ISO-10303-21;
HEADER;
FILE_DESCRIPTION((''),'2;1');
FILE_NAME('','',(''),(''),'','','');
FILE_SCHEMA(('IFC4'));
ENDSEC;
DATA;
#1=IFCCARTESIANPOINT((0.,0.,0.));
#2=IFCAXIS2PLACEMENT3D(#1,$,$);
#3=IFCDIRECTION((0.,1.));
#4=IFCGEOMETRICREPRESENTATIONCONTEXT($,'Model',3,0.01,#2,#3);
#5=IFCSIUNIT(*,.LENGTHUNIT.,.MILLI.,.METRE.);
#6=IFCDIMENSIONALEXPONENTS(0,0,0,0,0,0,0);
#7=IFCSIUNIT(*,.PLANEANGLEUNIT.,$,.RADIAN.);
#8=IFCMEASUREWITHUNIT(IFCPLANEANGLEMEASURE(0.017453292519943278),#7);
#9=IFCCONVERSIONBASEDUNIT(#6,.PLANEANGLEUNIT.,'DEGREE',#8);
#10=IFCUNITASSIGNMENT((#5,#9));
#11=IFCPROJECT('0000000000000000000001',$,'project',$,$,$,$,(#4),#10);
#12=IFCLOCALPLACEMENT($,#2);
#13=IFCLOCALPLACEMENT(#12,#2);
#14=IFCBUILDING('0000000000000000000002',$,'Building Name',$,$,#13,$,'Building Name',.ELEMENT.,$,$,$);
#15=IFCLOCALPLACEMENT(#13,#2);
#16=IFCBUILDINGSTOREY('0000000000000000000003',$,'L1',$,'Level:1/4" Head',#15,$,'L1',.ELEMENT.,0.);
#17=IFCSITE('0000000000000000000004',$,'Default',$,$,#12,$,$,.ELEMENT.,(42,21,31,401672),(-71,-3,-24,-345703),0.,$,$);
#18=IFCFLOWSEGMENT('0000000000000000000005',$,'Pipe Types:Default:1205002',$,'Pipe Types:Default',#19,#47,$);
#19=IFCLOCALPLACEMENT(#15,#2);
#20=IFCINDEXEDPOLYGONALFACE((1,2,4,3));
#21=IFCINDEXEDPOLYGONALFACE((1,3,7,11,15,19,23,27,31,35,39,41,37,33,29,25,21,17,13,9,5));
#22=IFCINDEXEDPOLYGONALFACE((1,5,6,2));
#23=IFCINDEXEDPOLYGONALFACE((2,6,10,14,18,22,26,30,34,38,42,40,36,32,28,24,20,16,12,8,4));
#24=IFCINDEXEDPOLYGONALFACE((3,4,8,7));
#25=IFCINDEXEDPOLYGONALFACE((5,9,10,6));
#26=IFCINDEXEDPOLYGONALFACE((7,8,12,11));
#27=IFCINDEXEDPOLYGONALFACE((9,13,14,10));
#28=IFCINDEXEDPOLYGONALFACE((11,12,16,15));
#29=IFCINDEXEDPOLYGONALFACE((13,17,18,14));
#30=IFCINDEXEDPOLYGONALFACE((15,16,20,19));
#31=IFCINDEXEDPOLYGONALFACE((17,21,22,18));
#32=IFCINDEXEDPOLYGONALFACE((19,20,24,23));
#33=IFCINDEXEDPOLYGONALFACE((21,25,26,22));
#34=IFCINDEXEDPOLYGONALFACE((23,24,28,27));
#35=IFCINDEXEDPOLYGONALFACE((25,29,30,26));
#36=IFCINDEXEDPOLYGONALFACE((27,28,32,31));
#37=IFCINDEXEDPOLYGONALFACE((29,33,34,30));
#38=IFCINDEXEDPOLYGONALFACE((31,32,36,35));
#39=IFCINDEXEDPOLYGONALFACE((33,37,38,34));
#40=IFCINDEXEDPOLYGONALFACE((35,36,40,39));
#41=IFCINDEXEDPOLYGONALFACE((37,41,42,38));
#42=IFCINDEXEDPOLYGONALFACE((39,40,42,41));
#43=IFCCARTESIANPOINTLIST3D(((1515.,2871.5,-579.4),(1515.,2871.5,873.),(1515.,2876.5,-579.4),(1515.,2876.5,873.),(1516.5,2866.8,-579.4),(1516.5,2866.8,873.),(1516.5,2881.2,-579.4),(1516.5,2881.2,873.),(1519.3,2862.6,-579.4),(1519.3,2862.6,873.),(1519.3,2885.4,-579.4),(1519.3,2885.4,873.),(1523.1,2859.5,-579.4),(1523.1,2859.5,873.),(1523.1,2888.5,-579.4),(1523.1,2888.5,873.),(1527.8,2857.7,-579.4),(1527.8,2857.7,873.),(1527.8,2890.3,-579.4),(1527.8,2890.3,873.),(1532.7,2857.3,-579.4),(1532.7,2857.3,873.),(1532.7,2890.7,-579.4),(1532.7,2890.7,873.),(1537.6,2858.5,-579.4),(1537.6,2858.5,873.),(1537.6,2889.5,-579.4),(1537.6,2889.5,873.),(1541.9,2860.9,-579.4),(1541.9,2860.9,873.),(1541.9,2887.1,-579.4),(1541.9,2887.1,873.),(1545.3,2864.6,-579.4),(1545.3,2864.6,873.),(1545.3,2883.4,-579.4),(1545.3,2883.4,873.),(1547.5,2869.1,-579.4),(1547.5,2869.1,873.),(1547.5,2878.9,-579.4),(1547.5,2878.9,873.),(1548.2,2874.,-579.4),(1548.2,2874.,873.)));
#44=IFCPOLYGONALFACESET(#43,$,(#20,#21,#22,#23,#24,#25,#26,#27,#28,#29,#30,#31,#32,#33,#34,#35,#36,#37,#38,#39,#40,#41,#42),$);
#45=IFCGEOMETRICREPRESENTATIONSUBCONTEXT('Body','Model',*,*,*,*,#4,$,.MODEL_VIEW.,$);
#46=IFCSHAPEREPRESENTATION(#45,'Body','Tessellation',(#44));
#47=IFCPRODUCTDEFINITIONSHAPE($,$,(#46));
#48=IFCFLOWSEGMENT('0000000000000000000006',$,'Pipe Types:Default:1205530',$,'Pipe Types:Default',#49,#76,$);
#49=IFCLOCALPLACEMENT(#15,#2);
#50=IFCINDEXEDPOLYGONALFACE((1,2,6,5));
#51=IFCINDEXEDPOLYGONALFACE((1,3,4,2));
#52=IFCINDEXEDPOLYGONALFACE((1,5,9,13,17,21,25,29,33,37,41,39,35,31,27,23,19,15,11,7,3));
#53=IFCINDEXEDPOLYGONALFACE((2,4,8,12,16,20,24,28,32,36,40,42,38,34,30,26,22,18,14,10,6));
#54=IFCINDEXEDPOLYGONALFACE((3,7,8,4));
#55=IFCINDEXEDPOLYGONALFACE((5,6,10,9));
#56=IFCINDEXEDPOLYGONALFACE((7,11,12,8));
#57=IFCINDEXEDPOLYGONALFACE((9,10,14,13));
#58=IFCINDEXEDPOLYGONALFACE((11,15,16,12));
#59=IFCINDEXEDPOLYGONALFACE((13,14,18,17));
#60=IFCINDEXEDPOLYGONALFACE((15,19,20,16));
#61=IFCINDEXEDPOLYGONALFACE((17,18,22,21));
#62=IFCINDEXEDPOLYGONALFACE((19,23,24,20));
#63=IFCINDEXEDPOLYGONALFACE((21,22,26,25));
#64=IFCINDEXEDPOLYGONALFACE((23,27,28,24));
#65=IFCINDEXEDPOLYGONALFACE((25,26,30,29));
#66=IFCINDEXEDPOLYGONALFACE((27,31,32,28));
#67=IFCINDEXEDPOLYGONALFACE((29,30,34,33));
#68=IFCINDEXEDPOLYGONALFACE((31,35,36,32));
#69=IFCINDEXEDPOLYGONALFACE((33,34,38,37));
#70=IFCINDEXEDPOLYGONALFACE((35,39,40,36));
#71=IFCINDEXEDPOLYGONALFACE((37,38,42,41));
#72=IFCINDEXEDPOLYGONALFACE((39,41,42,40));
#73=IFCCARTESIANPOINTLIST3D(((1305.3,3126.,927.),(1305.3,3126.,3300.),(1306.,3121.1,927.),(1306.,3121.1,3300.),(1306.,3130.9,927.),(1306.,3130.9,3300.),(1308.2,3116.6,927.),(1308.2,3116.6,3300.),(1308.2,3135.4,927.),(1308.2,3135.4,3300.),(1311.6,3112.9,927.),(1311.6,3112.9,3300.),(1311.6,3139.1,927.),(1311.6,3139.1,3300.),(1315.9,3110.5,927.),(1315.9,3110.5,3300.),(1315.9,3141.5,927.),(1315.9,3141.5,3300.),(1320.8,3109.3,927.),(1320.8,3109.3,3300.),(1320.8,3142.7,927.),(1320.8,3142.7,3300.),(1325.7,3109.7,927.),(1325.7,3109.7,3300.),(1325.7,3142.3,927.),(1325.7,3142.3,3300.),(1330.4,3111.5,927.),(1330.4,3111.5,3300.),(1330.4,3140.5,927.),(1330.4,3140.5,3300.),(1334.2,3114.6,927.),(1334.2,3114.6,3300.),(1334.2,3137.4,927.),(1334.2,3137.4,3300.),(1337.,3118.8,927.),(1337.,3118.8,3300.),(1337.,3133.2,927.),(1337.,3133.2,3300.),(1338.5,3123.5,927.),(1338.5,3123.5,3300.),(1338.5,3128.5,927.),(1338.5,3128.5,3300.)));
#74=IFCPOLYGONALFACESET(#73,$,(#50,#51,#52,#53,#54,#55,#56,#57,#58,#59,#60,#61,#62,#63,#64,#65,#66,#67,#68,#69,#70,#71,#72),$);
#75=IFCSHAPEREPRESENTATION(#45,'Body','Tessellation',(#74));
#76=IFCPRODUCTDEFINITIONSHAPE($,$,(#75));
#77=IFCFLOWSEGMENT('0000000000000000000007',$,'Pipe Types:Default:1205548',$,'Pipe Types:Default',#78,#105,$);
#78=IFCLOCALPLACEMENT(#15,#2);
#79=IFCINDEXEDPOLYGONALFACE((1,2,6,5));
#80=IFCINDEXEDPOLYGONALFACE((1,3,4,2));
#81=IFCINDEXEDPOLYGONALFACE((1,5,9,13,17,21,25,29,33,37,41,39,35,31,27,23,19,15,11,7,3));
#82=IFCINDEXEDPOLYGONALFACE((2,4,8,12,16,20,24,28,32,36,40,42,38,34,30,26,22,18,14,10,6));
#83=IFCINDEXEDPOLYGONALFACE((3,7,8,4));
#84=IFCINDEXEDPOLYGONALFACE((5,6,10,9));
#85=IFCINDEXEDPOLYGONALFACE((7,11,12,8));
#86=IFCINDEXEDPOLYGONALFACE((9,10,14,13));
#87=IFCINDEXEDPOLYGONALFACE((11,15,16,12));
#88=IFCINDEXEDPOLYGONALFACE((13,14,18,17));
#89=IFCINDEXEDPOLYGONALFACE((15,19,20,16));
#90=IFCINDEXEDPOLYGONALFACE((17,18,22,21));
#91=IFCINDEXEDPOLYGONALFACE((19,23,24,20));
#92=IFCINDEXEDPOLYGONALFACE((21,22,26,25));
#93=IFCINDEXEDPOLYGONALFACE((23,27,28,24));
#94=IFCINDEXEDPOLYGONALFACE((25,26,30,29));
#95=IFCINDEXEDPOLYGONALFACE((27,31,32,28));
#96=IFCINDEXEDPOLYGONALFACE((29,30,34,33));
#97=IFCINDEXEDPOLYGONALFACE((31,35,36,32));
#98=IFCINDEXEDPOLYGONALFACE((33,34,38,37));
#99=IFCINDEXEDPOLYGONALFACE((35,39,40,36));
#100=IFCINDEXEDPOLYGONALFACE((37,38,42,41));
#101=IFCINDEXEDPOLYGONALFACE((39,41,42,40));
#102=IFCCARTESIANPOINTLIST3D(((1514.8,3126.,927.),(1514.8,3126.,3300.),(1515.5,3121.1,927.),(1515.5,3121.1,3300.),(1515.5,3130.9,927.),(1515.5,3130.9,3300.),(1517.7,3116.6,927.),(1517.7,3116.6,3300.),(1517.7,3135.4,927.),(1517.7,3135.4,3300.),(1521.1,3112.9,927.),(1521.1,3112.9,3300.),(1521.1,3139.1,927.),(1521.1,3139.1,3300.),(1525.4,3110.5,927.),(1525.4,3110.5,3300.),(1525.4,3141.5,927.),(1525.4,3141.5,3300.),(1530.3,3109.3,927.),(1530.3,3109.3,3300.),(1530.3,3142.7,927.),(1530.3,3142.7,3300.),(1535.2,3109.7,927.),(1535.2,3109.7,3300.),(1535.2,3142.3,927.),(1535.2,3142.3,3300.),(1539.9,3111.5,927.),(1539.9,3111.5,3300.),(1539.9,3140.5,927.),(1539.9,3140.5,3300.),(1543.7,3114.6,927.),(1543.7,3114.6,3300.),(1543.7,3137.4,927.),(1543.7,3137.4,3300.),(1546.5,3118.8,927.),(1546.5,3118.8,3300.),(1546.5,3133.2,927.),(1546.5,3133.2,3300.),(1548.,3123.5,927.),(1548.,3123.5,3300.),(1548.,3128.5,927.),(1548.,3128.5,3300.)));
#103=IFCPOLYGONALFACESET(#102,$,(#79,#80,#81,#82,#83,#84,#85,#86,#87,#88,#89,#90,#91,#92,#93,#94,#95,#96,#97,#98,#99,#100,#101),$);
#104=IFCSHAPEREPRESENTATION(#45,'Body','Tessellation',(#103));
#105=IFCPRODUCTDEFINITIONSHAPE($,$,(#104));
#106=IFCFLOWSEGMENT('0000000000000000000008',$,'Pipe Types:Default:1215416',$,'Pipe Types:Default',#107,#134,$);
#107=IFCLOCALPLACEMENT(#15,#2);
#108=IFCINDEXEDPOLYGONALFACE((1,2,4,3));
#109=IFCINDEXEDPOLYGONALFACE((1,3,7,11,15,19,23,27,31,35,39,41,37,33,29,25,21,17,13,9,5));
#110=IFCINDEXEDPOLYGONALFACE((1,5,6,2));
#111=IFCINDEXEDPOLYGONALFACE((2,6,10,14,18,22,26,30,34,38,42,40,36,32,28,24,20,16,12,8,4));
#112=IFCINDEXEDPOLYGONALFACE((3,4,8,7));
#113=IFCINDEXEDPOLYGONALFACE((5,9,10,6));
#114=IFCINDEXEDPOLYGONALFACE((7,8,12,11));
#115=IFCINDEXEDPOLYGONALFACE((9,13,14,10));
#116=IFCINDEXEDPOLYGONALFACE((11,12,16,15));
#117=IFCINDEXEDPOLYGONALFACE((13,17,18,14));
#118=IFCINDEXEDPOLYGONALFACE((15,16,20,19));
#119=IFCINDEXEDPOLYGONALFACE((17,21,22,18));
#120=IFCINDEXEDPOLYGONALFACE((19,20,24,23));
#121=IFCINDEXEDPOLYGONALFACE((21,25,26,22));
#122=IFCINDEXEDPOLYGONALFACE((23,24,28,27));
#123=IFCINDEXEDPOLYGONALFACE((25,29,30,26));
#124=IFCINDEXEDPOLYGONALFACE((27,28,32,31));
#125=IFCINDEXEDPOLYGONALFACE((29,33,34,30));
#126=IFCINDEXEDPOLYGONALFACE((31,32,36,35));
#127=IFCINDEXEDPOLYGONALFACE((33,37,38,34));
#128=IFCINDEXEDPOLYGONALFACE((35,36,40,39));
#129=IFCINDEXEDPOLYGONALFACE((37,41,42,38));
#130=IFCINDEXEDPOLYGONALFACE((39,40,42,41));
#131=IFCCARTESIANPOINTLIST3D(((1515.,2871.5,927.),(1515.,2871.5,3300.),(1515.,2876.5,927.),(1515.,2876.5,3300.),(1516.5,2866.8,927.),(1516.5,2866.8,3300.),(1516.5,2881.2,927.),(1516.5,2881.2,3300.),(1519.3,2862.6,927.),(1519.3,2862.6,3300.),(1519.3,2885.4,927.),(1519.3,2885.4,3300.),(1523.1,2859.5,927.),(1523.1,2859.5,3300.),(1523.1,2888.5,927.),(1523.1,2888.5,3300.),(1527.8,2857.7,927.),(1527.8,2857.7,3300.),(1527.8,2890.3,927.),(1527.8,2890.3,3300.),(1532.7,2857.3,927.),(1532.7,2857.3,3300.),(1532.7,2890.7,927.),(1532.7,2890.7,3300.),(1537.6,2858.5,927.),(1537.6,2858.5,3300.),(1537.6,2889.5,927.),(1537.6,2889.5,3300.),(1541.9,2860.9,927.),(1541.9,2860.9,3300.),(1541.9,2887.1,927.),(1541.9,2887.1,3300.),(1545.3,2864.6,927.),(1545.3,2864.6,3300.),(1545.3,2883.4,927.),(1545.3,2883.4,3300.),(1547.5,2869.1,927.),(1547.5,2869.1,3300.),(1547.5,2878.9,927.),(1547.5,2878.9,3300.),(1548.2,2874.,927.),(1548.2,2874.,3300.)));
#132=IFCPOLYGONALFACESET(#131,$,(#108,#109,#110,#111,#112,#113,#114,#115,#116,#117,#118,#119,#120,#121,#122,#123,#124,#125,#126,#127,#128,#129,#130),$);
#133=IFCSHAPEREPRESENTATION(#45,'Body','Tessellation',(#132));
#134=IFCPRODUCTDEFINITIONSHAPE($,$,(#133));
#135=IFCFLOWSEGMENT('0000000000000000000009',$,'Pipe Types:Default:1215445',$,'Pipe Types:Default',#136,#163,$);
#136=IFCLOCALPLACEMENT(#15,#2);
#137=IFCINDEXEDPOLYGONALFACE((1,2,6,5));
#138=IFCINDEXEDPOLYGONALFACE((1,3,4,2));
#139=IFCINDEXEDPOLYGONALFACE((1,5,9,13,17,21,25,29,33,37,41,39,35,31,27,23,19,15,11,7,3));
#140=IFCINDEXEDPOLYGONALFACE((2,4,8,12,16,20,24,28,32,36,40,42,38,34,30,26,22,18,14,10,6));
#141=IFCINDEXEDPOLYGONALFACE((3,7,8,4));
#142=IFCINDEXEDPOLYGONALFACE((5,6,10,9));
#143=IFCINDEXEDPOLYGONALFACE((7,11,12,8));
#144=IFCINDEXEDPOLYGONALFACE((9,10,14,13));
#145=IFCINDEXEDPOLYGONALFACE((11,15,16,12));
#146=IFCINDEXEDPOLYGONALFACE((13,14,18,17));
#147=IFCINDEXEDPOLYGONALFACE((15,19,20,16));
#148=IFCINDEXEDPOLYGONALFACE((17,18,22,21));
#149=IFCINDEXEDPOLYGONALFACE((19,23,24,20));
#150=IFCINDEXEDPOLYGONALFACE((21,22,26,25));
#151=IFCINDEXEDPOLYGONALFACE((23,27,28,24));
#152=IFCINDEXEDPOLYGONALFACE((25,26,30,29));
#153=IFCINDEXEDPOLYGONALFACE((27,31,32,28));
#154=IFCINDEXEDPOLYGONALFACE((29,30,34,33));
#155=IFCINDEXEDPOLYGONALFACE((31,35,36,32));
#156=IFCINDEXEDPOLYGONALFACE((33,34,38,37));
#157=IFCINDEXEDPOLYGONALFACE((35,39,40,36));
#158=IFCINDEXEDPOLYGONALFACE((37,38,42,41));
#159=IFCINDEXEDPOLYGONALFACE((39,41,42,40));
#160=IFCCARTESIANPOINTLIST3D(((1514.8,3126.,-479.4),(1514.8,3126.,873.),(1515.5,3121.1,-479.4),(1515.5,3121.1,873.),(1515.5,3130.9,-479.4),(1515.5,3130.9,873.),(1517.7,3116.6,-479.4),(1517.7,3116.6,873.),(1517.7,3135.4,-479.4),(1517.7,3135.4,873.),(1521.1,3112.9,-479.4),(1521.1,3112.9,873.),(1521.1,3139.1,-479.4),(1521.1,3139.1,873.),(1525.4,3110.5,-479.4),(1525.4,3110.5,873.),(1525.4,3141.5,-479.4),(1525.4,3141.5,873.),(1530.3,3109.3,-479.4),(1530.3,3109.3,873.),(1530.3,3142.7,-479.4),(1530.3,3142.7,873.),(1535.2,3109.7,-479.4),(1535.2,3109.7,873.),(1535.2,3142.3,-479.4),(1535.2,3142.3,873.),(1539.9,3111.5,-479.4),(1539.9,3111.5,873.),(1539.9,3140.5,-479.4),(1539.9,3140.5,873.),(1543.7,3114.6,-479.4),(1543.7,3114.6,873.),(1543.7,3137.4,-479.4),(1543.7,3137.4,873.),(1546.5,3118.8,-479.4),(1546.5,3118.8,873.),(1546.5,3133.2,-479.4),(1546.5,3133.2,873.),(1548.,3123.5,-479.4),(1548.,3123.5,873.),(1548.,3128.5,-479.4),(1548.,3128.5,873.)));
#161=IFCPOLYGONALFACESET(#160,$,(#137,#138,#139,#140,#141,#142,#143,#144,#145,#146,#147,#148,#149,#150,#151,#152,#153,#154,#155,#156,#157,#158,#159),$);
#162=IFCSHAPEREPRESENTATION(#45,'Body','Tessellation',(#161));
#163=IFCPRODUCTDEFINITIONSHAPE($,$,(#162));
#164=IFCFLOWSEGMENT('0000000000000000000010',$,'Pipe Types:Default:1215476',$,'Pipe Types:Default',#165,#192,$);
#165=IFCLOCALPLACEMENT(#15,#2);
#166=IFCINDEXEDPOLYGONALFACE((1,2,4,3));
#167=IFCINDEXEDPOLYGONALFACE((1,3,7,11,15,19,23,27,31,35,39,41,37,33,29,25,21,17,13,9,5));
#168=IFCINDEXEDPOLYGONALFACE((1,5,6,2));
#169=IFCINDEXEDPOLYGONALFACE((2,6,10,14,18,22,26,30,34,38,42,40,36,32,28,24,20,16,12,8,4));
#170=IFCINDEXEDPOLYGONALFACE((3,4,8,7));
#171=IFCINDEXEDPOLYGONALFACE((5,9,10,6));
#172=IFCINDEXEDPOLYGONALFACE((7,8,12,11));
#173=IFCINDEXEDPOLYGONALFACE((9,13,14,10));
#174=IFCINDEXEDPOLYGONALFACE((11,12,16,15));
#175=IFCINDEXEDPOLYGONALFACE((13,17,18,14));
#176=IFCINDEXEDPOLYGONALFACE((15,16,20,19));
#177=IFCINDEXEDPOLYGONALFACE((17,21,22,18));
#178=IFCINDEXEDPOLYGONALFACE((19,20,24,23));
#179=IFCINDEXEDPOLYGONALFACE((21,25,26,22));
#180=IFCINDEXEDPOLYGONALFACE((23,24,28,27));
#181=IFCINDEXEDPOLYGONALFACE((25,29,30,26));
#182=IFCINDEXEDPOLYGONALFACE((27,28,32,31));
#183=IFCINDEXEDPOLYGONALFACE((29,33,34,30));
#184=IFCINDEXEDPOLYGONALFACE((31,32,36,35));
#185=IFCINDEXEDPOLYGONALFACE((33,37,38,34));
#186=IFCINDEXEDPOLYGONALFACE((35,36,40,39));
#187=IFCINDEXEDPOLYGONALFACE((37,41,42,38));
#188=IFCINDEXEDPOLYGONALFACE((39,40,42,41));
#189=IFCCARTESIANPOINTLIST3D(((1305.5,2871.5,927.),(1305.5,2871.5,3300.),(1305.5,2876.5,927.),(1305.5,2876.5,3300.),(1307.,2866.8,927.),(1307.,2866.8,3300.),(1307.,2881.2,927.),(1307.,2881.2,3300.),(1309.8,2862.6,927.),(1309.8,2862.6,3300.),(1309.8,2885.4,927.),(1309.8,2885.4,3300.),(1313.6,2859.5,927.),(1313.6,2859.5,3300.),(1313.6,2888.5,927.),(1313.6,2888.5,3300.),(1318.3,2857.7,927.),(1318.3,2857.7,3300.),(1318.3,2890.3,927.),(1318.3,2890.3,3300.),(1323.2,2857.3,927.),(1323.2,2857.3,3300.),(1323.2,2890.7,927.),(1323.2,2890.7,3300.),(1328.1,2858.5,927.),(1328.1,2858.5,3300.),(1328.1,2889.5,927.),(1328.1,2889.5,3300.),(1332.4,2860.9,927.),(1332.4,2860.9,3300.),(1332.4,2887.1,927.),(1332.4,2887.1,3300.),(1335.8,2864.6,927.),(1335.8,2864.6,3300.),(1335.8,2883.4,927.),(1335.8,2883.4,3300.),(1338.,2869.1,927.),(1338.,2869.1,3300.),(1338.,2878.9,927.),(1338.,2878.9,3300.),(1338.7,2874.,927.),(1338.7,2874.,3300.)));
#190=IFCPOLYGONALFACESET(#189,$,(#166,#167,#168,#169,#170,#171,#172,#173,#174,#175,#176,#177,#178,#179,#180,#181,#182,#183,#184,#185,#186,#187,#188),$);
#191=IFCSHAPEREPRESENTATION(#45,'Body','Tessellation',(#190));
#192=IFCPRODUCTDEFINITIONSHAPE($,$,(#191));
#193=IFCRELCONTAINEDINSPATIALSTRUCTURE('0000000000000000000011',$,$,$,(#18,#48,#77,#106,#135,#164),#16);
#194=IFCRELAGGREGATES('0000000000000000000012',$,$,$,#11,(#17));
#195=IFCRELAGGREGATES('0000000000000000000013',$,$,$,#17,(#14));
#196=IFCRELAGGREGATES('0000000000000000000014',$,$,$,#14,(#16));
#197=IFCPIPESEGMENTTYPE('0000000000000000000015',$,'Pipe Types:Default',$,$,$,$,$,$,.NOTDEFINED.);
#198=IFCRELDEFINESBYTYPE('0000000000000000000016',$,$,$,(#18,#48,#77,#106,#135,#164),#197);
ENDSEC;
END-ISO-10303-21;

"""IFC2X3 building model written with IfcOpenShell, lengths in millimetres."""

from ifc_helpers import new_model, entity, si_unit, converted_unit, direction, frame, origin, origin_2d_with_axis, place, context, subcontext, project, spatial, circle, extrude, type_object, element, save


model = new_model("IFC2X3")

# Units and contexts
model_context = context("Model", 3, precision=0.01, world=origin(), true_north=direction((0.0, 1.0)))
body_context = subcontext(model_context, "Body", "Model", "MODEL_VIEW")
ifc_project = project(units=[si_unit("LENGTHUNIT", "METRE", prefix="MILLI"), converted_unit("PLANEANGLEUNIT", "DEGREE", entity("IfcPlaneAngleMeasure", 0.017453292519943278), si_unit("PLANEANGLEUNIT", "RADIAN"), dimensions=[0, 0, 0, 0, 0, 0, 0])], contexts=[model_context])

# Site, building, storey
site_placement = place(None, origin())
site = spatial("IfcSite", under=ifc_project, at=site_placement, Name="Default", CompositionType="ELEMENT", RefLatitude=(42, 21, 31, 401672), RefLongitude=(-71, -3, -24, -345703), RefElevation=0.0)
building_placement = place(site_placement, origin())
building = spatial("IfcBuilding", under=site, at=building_placement, Name="Building Name", LongName="Building Name", CompositionType="ELEMENT")
storey_placement = place(building_placement, origin())
storey = spatial("IfcBuildingStorey", under=building, at=storey_placement, Name="L1", ObjectType="Level:1/4\" Head", LongName="L1", CompositionType="ELEMENT", Elevation=0.0)

# Flow segments
pipe_segment_type = type_object("IfcPipeSegmentType", Name="Pipe Types:Default", PredefinedType="NOTDEFINED")
flow_segment_1_placement = place(storey_placement, origin())
element("IfcFlowSegment", 1, at=flow_segment_1_placement, inside=storey, type_object=pipe_segment_type, Name="Pipe Types:Default:1205002", ObjectType="Pipe Types:Default", context=body_context, shape_type="SweptSolid", body=[
    extrude(circle(Radius=16.7, at=origin_2d_with_axis()), frame((1531.5, 2874.0, -579.4)), (0.0, 0.0, 1.0), 1452.4),
])
flow_segment_2_placement = place(storey_placement, origin())
element("IfcFlowSegment", 2, at=flow_segment_2_placement, inside=storey, type_object=pipe_segment_type, Name="Pipe Types:Default:1205530", ObjectType="Pipe Types:Default", context=body_context, shape_type="SweptSolid", body=[
    extrude(circle(Radius=16.7, at=origin_2d_with_axis()), frame((1322.0, 3126.0, 927.0), z_axis=(0.0, 0.0, 1.0), x_axis=(-1.0, 0.0, 0.0)), (0.0, 0.0, 1.0), 2373.0),
])
flow_segment_3_placement = place(storey_placement, origin())
element("IfcFlowSegment", 3, at=flow_segment_3_placement, inside=storey, type_object=pipe_segment_type, Name="Pipe Types:Default:1205548", ObjectType="Pipe Types:Default", context=body_context, shape_type="SweptSolid", body=[
    extrude(circle(Radius=16.7, at=origin_2d_with_axis()), frame((1531.5, 3126.0, 927.0), z_axis=(0.0, 0.0, 1.0), x_axis=(-1.0, 0.0, 0.0)), (0.0, 0.0, 1.0), 2373.0),
])
flow_segment_4_placement = place(storey_placement, origin())
element("IfcFlowSegment", 4, at=flow_segment_4_placement, inside=storey, type_object=pipe_segment_type, Name="Pipe Types:Default:1215416", ObjectType="Pipe Types:Default", context=body_context, shape_type="SweptSolid", body=[
    extrude(circle(Radius=16.7, at=origin_2d_with_axis()), frame((1531.5, 2874.0, 927.0)), (0.0, 0.0, 1.0), 2373.0),
])
flow_segment_5_placement = place(storey_placement, origin())
element("IfcFlowSegment", 5, at=flow_segment_5_placement, inside=storey, type_object=pipe_segment_type, Name="Pipe Types:Default:1215445", ObjectType="Pipe Types:Default", context=body_context, shape_type="SweptSolid", body=[
    extrude(circle(Radius=16.7, at=origin_2d_with_axis()), frame((1531.5, 3126.0, -479.4), z_axis=(0.0, 0.0, 1.0), x_axis=(-1.0, 0.0, 0.0)), (0.0, 0.0, 1.0), 1352.4),
])
flow_segment_6_placement = place(storey_placement, origin())
element("IfcFlowSegment", 6, at=flow_segment_6_placement, inside=storey, type_object=pipe_segment_type, Name="Pipe Types:Default:1215476", ObjectType="Pipe Types:Default", context=body_context, shape_type="SweptSolid", body=[
    extrude(circle(Radius=16.7, at=origin_2d_with_axis()), frame((1322.0, 2874.0, 927.0)), (0.0, 0.0, 1.0), 2373.0),
])

save(model, "model.ifc")
